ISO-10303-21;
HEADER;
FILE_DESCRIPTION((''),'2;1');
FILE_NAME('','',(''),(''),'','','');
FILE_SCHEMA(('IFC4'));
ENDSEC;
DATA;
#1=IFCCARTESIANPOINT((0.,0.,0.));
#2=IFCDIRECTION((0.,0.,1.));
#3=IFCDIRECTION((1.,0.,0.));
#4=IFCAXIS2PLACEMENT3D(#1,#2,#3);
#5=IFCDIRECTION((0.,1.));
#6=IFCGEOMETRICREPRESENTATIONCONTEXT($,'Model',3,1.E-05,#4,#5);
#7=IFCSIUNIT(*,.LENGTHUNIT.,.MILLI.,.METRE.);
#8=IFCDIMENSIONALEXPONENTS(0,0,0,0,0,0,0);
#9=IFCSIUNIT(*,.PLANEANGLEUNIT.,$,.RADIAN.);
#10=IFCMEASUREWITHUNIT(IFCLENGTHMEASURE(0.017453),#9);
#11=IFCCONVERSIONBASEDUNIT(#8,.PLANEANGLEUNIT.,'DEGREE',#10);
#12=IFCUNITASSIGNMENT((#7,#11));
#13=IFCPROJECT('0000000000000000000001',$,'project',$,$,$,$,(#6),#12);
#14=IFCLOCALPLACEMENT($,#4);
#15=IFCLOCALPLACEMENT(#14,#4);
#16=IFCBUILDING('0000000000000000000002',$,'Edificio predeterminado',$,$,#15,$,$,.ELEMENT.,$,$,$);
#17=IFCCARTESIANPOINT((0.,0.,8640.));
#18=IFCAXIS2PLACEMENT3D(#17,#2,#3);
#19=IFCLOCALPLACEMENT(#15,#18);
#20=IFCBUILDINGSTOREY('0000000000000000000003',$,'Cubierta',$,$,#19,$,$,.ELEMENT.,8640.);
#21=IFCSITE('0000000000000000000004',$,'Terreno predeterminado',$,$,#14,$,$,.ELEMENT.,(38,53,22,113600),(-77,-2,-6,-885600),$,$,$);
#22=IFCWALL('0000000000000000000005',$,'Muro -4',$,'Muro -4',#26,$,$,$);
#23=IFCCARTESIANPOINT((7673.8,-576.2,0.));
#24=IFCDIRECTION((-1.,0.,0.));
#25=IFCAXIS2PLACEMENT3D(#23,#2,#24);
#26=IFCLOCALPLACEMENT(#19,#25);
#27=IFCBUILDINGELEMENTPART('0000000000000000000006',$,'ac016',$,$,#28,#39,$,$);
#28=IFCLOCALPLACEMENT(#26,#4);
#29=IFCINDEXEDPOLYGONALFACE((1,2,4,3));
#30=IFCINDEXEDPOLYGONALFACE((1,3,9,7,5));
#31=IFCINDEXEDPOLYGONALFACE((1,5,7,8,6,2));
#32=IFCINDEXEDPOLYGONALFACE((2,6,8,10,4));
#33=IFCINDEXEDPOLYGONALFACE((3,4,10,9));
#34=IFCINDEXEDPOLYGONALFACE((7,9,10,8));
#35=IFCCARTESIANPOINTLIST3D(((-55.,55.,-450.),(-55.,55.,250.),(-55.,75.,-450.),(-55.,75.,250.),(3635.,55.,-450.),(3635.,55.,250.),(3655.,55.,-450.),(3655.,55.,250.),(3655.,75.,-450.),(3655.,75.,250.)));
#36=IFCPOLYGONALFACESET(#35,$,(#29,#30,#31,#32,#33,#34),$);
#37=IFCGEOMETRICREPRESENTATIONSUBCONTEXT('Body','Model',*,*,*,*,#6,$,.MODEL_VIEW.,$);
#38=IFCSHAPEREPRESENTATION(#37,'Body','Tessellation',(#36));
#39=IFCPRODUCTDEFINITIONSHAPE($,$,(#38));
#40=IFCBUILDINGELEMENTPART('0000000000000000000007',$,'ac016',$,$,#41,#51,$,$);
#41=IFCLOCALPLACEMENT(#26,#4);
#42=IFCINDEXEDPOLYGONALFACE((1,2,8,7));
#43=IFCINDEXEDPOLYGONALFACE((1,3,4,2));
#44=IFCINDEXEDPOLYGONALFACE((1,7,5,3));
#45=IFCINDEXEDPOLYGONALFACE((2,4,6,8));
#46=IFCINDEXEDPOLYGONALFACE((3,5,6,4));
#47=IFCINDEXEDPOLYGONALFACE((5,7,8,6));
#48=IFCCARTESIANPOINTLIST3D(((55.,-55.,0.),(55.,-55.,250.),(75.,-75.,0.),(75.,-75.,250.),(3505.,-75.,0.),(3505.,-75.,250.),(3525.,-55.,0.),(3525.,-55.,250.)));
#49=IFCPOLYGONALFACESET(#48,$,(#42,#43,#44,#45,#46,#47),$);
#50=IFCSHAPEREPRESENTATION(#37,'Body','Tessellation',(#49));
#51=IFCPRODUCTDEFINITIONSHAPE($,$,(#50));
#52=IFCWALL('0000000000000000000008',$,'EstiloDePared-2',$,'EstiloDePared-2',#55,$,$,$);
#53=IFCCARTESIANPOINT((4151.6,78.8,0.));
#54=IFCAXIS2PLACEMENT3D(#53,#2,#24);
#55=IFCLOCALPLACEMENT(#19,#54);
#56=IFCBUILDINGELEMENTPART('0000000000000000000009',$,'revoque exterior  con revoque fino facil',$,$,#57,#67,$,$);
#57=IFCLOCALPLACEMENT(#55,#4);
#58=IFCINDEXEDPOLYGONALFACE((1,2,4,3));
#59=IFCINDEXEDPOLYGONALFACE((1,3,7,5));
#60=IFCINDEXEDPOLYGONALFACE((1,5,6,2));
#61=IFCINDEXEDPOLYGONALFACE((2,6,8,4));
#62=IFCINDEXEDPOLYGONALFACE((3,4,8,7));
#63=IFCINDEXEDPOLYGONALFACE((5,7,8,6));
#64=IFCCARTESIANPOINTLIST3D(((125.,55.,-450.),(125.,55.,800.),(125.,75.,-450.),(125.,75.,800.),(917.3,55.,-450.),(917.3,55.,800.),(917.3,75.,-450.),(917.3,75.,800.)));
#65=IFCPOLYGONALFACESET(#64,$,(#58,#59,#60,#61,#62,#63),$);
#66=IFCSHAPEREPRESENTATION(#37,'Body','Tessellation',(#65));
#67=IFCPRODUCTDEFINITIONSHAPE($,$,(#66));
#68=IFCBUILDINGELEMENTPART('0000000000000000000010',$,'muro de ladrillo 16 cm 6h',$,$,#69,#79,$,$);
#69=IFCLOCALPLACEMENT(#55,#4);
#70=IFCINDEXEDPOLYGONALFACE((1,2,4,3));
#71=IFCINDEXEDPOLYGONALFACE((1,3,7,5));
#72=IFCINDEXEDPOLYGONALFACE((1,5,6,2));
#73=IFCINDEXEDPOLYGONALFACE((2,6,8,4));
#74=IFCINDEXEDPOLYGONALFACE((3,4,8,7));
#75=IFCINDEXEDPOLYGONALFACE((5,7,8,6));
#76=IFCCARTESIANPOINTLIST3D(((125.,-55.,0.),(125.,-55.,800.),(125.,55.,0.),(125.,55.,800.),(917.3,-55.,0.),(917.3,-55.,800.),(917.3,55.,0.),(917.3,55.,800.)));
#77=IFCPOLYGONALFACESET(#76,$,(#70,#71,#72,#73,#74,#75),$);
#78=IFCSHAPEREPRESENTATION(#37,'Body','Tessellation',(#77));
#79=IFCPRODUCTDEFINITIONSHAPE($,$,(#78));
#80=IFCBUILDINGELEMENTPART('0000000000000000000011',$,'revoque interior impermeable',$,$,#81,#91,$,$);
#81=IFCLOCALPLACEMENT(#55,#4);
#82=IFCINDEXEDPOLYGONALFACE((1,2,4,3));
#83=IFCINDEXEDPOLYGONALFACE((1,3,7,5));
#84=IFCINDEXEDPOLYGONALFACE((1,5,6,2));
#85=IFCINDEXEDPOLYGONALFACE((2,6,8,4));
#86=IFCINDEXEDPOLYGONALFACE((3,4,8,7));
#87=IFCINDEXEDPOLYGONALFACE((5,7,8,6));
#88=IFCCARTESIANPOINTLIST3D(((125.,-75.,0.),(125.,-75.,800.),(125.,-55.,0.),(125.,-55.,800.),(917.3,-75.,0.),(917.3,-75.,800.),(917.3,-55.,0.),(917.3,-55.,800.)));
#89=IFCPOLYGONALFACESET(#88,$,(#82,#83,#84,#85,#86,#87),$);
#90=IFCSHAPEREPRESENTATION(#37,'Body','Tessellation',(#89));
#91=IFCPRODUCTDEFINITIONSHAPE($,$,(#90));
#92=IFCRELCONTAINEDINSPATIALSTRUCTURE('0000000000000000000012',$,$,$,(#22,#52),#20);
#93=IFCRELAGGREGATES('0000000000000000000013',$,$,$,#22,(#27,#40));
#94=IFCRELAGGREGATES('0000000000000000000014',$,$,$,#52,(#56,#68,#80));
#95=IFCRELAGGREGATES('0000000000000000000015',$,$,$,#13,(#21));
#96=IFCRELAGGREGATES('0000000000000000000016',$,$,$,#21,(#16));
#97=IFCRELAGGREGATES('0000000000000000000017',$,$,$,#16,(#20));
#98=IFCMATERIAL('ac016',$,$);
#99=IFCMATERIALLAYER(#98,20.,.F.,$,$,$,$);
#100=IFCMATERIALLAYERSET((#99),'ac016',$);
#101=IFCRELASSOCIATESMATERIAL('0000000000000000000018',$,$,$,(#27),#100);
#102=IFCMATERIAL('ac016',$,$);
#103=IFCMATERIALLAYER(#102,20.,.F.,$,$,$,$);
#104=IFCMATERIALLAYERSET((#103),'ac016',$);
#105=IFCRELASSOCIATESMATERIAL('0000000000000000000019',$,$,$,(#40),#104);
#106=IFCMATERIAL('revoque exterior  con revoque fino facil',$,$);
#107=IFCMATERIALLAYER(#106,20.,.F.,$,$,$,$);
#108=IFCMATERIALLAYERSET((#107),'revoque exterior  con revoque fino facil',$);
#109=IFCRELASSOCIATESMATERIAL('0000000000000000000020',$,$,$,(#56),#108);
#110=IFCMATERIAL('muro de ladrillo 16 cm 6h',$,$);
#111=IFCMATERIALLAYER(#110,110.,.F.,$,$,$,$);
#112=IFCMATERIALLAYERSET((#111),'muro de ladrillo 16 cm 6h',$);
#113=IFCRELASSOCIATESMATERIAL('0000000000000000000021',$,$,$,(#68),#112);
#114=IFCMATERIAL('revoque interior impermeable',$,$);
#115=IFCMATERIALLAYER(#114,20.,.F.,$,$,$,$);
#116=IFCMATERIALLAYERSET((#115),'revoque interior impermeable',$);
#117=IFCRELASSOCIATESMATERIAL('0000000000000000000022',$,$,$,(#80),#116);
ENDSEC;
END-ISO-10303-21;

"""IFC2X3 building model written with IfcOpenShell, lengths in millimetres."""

from ifc_helpers import new_model, entity, si_unit, converted_unit, direction, frame, origin_with_axes, place, context, subcontext, project, spatial, polyline, outline, extrude, material, layer, layer_set, layer_usage, element, aggregate, save


model = new_model("IFC2X3")

# Units and contexts
model_context = context("Model", 3, precision=1e-05, world=origin_with_axes(), true_north=direction((0.0, 1.0)))
body_context = subcontext(model_context, "Body", "Model", "MODEL_VIEW")
ifc_project = project(units=[si_unit("LENGTHUNIT", "METRE", prefix="MILLI"), converted_unit("PLANEANGLEUNIT", "DEGREE", entity("IfcLengthMeasure", 0.017453), si_unit("PLANEANGLEUNIT", "RADIAN"), dimensions=[0, 0, 0, 0, 0, 0, 0])], contexts=[model_context])

# Site, building, storey
site_placement = place(None, origin_with_axes())
site = spatial("IfcSite", under=ifc_project, at=site_placement, Name="Terreno predeterminado", CompositionType="ELEMENT", RefLatitude=(38, 53, 22, 113600), RefLongitude=(-77, -2, -6, -885600))
building_placement = place(site_placement, origin_with_axes())
building = spatial("IfcBuilding", under=site, at=building_placement, Name="Edificio predeterminado", CompositionType="ELEMENT")
storey_placement = place(building_placement, frame((0.0, 0.0, 8640.0), z_axis=(0.0, 0.0, 1.0), x_axis=(1.0, 0.0, 0.0)))
storey = spatial("IfcBuildingStorey", under=building, at=storey_placement, Name="Cubierta", CompositionType="ELEMENT", Elevation=8640.0)

# Walls, building element parts
wall_1_placement = place(storey_placement, frame((7673.8, -576.2, 0.0), z_axis=(0.0, 0.0, 1.0), x_axis=(-1.0, 0.0, 0.0)))
wall_1 = element("IfcWall", 1, at=wall_1_placement, inside=storey, Name="Muro -4", ObjectType="Muro -4")
ifc_material_1 = material(Name="ac016")
ifc_layer_1 = layer(ifc_material_1, 20.0, ventilated=False)
ifc_layer_set_1 = layer_set([ifc_layer_1], Name="ac016")
ifc_layer_usage_1 = layer_usage(ifc_layer_set_1, "AXIS2", "NEGATIVE", -75.0)
building_element_part_1_placement = place(wall_1_placement, origin_with_axes())
building_element_part_1 = element("IfcBuildingElementPart", 2, at=building_element_part_1_placement, material=ifc_layer_usage_1, Name="ac016", context=body_context, shape_type="SweptSolid", body=[
    extrude(outline(polyline([(3655.0, 75.0), (3655.0, 55.0), (3635.0, 55.0), (-55.0, 55.0), (-55.0, 75.0), (3655.0, 75.0)])), frame((0.0, 0.0, -450.0), z_axis=(0.0, 0.0, 1.0), x_axis=(1.0, 0.0, 0.0)), (0.0, 0.0, 1.0), 700.0),
])
ifc_material_2 = material(Name="ac016")
ifc_layer_2 = layer(ifc_material_2, 20.0, ventilated=False)
ifc_layer_set_2 = layer_set([ifc_layer_2], Name="ac016")
ifc_layer_usage_2 = layer_usage(ifc_layer_set_2, "AXIS2", "NEGATIVE", 55.0)
building_element_part_2_placement = place(wall_1_placement, origin_with_axes())
building_element_part_2 = element("IfcBuildingElementPart", 3, at=building_element_part_2_placement, material=ifc_layer_usage_2, Name="ac016", context=body_context, shape_type="SweptSolid", body=[
    extrude(outline(polyline([(3525.0, -55.0), (3505.0, -75.0), (75.0, -75.0), (55.0, -55.0), (3525.0, -55.0)])), origin_with_axes(), (0.0, 0.0, 1.0), 250.0),
])
aggregate(wall_1, [building_element_part_1, building_element_part_2])
wall_2_placement = place(storey_placement, frame((4151.6, 78.8, 0.0), z_axis=(0.0, 0.0, 1.0), x_axis=(-1.0, 0.0, 0.0)))
wall_2 = element("IfcWall", 4, at=wall_2_placement, inside=storey, Name="EstiloDePared-2", ObjectType="EstiloDePared-2")
ifc_material_3 = material(Name="revoque exterior  con revoque fino facil")
ifc_layer_3 = layer(ifc_material_3, 20.0, ventilated=False)
ifc_layer_set_3 = layer_set([ifc_layer_3], Name="revoque exterior  con revoque fino facil")
ifc_layer_usage_3 = layer_usage(ifc_layer_set_3, "AXIS2", "NEGATIVE", -75.0)
building_element_part_3_placement = place(wall_2_placement, origin_with_axes())
building_element_part_3 = element("IfcBuildingElementPart", 5, at=building_element_part_3_placement, material=ifc_layer_usage_3, Name="revoque exterior  con revoque fino facil", context=body_context, shape_type="SweptSolid", body=[
    extrude(outline(polyline([(917.3, 75.0), (917.3, 55.0), (125.0, 55.0), (125.0, 75.0), (917.3, 75.0)])), frame((0.0, 0.0, -450.0), z_axis=(0.0, 0.0, 1.0), x_axis=(1.0, 0.0, 0.0)), (0.0, 0.0, 1.0), 1250.0),
])
ifc_material_4 = material(Name="muro de ladrillo 16 cm 6h")
ifc_layer_4 = layer(ifc_material_4, 110.0, ventilated=False)
ifc_layer_set_4 = layer_set([ifc_layer_4], Name="muro de ladrillo 16 cm 6h")
ifc_layer_usage_4 = layer_usage(ifc_layer_set_4, "AXIS2", "NEGATIVE", -55.0)
building_element_part_4_placement = place(wall_2_placement, origin_with_axes())
building_element_part_4 = element("IfcBuildingElementPart", 6, at=building_element_part_4_placement, material=ifc_layer_usage_4, Name="muro de ladrillo 16 cm 6h", context=body_context, shape_type="SweptSolid", body=[
    extrude(outline(polyline([(917.3, 55.0), (917.3, -55.0), (125.0, -55.0), (125.0, 55.0), (917.3, 55.0)])), origin_with_axes(), (0.0, 0.0, 1.0), 800.0),
])
ifc_material_5 = material(Name="revoque interior impermeable")
ifc_layer_5 = layer(ifc_material_5, 20.0, ventilated=False)
ifc_layer_set_5 = layer_set([ifc_layer_5], Name="revoque interior impermeable")
ifc_layer_usage_5 = layer_usage(ifc_layer_set_5, "AXIS2", "NEGATIVE", 55.0)
building_element_part_5_placement = place(wall_2_placement, origin_with_axes())
building_element_part_5 = element("IfcBuildingElementPart", 7, at=building_element_part_5_placement, material=ifc_layer_usage_5, Name="revoque interior impermeable", context=body_context, shape_type="SweptSolid", body=[
    extrude(outline(polyline([(917.3, -55.0), (917.3, -75.0), (125.0, -75.0), (125.0, -55.0), (917.3, -55.0)])), origin_with_axes(), (0.0, 0.0, 1.0), 800.0),
])
aggregate(wall_2, [building_element_part_3, building_element_part_4, building_element_part_5])

save(model, "model.ifc")
